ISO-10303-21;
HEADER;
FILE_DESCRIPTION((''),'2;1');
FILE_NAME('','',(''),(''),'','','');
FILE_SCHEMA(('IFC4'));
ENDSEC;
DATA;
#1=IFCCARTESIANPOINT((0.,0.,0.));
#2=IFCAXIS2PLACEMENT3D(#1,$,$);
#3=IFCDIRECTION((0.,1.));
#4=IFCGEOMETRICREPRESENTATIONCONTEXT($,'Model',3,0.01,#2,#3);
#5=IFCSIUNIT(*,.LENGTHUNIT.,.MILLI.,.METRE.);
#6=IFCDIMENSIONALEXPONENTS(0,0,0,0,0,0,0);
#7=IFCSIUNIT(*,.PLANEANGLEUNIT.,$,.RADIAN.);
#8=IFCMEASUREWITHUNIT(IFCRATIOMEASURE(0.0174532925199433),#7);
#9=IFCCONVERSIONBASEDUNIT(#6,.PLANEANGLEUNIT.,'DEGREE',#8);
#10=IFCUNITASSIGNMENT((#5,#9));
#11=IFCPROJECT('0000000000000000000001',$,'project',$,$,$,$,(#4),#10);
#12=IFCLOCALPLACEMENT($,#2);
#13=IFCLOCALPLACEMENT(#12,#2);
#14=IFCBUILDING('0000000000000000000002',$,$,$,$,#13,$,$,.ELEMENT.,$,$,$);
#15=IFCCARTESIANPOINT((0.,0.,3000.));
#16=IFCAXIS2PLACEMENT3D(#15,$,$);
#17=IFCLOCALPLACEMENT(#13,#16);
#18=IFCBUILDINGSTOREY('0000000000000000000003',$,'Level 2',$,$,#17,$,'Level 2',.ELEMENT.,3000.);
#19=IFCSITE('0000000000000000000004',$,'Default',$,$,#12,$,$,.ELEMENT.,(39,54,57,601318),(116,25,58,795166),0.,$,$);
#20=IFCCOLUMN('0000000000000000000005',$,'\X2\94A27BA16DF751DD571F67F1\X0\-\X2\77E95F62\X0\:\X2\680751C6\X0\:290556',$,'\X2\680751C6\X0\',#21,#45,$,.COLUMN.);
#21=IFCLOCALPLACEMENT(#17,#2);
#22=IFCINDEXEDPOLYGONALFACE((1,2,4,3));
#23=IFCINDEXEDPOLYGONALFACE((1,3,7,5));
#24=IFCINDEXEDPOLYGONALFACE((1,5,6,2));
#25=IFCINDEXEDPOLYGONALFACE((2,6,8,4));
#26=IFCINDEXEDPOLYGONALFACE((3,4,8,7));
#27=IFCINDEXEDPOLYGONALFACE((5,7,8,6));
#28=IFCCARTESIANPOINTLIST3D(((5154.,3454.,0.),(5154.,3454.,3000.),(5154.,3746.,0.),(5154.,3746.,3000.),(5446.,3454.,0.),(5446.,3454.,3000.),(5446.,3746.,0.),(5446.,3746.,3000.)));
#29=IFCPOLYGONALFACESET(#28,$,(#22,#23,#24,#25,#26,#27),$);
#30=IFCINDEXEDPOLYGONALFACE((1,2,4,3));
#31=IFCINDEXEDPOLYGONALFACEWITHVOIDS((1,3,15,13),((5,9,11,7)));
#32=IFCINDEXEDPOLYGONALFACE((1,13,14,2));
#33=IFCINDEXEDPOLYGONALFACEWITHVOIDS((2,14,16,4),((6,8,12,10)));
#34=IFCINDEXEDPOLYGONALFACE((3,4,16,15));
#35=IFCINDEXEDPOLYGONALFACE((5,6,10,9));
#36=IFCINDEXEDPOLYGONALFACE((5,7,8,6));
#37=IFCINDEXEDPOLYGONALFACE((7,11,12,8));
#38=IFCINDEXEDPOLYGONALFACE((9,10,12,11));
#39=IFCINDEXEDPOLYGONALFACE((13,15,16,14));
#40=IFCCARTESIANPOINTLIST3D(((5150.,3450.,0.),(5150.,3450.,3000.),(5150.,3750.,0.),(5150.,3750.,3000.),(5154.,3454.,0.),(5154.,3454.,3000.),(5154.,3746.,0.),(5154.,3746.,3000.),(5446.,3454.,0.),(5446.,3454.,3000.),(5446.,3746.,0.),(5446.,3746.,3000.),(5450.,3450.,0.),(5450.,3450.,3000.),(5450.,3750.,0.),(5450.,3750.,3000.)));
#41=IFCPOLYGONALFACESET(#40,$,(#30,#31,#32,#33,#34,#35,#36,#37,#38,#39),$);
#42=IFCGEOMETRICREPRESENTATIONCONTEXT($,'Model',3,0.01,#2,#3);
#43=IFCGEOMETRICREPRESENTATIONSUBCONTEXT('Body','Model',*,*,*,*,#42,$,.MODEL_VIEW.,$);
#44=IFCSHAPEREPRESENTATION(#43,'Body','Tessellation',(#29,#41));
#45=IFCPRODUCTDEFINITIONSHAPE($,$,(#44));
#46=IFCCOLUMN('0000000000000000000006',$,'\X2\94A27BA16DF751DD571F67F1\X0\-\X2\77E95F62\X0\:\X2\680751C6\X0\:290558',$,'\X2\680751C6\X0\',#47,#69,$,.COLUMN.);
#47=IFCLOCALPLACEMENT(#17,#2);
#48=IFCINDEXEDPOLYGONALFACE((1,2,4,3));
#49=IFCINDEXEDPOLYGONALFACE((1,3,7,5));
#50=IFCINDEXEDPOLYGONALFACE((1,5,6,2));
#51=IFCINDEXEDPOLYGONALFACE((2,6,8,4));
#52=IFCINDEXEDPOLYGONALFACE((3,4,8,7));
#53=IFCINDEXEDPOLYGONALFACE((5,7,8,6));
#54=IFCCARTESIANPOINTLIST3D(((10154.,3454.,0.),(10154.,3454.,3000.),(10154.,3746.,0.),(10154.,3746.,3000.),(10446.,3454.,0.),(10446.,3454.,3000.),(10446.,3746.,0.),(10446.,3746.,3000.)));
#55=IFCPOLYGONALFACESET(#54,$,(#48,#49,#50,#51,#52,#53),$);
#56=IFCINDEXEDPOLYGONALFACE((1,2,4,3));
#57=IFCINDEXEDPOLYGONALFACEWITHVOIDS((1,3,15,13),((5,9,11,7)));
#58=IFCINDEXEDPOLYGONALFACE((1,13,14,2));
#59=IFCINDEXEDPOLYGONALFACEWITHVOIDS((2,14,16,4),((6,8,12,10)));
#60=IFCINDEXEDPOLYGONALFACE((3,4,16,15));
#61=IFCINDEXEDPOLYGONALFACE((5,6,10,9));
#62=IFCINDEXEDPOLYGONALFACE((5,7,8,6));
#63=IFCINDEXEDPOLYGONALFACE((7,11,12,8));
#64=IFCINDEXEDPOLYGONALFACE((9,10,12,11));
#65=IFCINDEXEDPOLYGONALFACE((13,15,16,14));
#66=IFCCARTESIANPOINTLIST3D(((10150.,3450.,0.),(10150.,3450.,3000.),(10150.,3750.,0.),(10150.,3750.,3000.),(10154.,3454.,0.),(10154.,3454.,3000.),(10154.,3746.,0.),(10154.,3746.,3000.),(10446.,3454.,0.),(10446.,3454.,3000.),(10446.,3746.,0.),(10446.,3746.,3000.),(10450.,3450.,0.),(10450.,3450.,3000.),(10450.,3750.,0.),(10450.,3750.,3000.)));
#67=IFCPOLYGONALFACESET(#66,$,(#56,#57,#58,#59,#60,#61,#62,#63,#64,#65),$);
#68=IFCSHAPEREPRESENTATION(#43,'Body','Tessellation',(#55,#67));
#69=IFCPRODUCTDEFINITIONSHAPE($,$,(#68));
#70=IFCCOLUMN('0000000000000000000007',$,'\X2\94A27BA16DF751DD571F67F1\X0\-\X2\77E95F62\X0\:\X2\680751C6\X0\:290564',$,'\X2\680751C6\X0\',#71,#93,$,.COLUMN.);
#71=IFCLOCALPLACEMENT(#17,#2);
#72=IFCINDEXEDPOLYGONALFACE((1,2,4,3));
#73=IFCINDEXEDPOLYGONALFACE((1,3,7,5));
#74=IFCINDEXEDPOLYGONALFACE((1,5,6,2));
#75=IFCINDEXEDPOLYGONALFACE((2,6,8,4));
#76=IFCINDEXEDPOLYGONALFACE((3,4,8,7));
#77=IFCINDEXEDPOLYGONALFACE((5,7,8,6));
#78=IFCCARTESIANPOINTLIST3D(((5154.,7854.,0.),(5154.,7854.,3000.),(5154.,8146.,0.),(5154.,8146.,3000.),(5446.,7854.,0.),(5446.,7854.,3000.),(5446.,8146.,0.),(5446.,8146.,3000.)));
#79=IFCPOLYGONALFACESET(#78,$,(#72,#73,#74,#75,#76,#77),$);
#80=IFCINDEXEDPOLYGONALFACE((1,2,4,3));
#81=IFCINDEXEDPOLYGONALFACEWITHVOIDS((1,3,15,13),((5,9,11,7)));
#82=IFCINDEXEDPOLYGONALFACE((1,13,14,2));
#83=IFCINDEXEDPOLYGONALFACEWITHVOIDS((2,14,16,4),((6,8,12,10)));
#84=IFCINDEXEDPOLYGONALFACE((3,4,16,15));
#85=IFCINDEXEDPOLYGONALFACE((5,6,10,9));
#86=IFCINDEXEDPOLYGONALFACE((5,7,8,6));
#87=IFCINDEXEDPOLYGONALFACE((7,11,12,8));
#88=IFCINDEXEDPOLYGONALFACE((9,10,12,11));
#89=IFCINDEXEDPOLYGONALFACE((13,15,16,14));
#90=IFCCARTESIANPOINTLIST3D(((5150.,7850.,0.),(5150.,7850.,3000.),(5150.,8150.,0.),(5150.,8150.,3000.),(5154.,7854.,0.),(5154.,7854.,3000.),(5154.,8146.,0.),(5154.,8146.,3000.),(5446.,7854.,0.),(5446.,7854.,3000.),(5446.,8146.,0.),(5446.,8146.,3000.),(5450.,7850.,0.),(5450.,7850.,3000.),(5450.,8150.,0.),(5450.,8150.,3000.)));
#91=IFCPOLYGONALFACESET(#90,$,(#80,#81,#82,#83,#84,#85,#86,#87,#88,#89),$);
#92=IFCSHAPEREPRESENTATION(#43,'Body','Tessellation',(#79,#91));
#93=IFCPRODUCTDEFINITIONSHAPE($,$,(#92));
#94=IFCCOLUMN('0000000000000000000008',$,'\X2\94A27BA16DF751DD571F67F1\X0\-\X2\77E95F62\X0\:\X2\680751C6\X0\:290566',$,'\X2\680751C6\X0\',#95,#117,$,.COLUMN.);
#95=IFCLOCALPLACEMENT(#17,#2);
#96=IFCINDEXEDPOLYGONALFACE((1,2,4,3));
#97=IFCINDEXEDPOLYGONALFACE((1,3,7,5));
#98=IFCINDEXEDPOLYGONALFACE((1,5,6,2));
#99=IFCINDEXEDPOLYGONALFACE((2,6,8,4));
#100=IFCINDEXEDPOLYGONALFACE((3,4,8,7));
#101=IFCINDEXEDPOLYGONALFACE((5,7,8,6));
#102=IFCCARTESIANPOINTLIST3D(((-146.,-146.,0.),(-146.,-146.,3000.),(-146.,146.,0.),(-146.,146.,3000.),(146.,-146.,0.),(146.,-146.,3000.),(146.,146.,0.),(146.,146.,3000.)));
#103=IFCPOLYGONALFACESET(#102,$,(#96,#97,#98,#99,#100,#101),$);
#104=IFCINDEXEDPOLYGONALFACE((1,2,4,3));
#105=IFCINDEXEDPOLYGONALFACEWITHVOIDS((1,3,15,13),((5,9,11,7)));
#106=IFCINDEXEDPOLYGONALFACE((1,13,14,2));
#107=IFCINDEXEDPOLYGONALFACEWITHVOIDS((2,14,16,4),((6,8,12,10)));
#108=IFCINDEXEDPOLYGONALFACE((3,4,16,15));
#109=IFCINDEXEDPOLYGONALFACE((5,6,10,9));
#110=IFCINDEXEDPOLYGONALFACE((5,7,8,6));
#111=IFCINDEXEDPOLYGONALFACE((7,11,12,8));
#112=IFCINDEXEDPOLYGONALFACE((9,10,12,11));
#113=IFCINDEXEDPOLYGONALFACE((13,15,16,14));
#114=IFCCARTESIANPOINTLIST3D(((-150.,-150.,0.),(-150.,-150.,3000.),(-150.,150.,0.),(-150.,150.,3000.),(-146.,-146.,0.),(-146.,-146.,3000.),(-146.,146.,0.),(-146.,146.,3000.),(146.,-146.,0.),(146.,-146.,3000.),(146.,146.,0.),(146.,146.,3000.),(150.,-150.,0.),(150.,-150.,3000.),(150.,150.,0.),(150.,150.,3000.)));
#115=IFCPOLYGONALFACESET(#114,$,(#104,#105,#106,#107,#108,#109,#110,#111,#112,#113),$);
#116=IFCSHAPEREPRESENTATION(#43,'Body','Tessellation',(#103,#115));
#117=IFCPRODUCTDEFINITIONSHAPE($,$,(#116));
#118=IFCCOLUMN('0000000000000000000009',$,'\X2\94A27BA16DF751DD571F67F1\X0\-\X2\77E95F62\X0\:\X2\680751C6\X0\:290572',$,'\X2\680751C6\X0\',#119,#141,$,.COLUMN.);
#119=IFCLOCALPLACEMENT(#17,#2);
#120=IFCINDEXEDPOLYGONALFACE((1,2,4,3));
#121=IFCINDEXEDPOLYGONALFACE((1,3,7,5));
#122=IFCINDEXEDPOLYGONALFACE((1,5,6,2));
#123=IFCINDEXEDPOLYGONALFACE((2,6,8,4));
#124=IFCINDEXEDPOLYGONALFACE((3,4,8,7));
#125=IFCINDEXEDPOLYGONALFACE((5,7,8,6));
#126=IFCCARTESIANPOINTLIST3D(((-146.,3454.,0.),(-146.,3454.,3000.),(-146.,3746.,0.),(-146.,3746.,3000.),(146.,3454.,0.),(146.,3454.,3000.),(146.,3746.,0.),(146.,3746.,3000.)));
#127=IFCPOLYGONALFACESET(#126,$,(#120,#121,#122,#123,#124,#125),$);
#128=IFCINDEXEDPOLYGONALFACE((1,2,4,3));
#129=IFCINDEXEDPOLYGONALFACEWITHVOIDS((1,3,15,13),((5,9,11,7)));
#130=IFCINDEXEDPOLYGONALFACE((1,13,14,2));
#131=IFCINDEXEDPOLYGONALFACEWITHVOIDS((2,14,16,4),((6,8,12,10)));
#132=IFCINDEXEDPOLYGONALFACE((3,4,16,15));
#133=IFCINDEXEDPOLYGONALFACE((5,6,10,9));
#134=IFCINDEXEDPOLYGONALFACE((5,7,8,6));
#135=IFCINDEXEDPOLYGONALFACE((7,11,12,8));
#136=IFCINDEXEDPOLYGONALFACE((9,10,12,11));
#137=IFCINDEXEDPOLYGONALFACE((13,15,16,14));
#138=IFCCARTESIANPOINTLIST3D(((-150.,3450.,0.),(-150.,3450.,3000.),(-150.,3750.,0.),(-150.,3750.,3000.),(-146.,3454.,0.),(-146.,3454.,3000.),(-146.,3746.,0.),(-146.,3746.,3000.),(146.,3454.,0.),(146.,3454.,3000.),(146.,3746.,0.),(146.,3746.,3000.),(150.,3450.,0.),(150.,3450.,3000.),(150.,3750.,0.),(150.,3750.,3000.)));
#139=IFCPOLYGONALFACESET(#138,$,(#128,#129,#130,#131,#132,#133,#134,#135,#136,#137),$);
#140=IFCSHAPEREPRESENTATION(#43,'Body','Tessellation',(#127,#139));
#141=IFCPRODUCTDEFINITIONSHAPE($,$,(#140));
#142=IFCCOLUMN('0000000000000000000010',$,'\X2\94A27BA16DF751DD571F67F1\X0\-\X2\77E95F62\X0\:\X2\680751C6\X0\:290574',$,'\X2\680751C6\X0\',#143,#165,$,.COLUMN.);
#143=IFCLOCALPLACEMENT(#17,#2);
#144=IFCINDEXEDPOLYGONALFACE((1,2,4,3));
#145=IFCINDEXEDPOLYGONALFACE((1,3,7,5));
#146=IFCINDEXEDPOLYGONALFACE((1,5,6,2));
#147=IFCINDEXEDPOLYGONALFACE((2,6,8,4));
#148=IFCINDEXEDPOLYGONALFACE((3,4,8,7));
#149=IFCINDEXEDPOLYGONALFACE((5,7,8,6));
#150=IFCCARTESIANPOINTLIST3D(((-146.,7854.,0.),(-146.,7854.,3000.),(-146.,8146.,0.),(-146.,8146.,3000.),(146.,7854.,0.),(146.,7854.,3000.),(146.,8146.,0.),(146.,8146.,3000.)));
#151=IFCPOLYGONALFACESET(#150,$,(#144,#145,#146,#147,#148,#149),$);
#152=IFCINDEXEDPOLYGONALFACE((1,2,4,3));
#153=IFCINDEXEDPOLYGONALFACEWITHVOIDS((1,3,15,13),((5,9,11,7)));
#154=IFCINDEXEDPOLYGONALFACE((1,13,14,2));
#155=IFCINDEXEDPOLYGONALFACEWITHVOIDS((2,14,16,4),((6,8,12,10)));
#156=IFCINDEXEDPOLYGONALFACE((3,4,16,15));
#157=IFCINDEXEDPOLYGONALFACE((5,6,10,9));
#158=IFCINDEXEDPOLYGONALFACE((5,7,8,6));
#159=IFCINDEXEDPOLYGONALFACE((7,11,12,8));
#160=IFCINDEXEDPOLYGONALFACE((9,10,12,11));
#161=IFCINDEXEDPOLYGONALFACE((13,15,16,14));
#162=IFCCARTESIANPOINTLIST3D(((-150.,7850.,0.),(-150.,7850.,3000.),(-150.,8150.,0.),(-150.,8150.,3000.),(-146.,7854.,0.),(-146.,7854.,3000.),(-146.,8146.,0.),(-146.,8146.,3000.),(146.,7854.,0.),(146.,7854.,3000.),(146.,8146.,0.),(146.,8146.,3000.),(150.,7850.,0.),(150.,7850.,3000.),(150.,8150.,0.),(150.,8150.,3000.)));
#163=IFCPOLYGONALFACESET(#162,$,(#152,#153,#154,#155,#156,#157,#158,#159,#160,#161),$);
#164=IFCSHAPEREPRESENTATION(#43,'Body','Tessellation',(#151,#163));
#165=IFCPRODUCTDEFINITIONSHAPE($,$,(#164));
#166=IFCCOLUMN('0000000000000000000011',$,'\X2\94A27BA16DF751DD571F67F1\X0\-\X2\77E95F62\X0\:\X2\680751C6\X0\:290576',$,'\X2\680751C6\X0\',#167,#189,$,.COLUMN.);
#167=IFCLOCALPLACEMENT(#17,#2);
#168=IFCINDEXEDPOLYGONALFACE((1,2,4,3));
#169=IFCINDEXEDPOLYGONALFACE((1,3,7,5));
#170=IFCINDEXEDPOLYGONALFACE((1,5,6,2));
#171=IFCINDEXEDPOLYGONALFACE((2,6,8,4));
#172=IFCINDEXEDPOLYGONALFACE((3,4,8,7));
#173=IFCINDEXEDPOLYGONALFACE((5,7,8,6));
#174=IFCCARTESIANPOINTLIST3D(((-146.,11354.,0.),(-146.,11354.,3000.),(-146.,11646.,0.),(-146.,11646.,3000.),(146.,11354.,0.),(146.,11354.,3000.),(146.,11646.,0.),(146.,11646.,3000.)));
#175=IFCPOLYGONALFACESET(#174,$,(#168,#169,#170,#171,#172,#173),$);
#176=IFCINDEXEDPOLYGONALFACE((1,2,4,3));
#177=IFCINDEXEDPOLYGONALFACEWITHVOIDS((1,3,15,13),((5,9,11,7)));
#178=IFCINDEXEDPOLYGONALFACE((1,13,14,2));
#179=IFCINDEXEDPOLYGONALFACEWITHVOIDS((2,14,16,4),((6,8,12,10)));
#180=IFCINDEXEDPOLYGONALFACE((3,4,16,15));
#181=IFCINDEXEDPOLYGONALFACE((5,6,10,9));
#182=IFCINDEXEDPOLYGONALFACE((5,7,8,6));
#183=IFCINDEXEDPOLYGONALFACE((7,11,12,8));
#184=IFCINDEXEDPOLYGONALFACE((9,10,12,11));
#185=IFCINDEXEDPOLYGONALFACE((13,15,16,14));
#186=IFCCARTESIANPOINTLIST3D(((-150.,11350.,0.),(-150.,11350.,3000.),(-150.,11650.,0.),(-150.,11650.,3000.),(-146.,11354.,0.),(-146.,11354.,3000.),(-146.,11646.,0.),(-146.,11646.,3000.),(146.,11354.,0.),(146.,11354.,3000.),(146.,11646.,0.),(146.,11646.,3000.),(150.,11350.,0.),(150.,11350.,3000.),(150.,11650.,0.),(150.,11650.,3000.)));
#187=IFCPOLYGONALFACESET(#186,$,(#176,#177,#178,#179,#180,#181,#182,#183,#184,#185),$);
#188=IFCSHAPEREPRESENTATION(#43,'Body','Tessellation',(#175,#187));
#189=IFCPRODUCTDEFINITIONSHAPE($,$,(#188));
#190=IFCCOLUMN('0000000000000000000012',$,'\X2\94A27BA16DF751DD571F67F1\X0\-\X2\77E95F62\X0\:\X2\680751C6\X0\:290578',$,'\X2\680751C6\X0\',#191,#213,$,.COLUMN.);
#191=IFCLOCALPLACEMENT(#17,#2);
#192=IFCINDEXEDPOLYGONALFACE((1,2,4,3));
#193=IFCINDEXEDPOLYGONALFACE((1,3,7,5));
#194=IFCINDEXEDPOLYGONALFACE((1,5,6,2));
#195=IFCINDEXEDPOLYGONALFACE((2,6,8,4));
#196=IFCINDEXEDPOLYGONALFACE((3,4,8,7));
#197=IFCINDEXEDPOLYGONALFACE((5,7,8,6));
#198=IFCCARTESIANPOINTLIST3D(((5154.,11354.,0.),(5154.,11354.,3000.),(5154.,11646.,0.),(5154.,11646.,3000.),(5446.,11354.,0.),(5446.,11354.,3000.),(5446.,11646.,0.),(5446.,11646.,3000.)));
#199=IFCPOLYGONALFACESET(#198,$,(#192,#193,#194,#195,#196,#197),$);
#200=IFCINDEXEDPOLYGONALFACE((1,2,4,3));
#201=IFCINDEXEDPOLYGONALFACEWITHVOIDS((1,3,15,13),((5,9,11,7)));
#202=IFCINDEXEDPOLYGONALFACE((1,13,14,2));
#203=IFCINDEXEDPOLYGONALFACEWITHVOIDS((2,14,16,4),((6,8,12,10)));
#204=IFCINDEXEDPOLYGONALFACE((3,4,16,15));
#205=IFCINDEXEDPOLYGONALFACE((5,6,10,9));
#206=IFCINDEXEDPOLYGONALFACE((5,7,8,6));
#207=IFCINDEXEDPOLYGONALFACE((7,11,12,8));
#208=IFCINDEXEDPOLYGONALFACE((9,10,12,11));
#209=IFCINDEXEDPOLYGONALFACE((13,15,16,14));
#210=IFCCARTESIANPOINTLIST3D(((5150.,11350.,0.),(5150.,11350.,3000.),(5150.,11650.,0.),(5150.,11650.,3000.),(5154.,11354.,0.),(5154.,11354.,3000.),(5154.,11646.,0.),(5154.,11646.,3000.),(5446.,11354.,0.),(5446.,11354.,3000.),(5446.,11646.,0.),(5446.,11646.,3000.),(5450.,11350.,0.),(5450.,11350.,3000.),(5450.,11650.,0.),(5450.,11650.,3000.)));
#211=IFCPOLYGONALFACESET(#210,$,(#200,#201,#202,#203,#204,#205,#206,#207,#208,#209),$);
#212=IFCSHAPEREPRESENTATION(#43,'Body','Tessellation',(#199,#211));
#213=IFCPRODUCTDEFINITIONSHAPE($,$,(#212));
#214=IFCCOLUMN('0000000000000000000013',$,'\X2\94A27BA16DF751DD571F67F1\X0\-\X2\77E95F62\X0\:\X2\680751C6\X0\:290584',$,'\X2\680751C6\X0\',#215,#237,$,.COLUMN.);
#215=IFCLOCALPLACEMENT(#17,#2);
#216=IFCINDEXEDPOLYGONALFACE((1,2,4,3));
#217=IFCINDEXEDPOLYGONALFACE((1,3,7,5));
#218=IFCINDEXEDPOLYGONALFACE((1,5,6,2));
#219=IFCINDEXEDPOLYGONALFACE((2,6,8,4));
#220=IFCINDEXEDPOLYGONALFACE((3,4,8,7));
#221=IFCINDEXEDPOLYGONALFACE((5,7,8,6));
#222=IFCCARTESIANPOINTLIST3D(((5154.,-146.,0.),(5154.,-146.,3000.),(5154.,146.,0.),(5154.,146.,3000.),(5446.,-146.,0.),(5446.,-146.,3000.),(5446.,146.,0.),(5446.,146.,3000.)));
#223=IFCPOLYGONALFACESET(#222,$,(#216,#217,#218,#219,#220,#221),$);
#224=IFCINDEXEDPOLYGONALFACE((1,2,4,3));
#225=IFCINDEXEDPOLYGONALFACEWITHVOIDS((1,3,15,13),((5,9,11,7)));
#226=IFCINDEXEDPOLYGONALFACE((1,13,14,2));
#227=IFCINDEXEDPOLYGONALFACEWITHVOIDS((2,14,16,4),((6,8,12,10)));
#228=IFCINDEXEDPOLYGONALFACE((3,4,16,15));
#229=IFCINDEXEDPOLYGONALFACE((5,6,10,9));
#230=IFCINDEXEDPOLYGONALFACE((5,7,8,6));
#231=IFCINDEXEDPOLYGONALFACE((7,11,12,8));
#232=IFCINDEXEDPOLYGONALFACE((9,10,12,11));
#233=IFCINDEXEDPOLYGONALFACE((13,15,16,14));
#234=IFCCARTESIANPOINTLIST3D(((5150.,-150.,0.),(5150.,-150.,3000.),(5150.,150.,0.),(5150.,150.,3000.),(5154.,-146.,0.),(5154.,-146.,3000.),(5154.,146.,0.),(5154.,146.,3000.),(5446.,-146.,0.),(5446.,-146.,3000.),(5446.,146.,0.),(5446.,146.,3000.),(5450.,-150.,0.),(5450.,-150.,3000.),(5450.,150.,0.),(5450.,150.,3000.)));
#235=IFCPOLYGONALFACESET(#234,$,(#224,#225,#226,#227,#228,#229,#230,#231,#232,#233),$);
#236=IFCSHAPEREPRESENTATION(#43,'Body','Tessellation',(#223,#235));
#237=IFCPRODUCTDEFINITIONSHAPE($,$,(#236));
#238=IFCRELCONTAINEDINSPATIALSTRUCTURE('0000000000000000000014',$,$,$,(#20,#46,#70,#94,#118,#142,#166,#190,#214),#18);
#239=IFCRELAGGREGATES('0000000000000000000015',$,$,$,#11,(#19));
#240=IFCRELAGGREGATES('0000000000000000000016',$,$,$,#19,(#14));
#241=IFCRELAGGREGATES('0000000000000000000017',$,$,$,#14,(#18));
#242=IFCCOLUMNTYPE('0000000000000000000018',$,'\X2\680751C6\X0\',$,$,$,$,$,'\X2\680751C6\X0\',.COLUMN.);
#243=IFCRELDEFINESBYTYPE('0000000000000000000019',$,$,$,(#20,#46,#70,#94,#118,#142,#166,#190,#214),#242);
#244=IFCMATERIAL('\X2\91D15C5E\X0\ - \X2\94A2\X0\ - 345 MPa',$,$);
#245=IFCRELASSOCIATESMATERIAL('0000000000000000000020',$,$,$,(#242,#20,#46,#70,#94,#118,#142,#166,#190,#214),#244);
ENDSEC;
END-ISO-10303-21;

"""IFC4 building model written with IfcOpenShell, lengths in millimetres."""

from ifc_helpers import new_model, entity, si_unit, converted_unit, direction, frame, origin, origin_2d_with_axis, place, context, subcontext, project, spatial, polyline, rectangle, outline, extrude, source, transform, mapped, material, type_object, type_shapes, element, save


model = new_model("IFC4")

# Units and contexts
model_context_1 = context("Model", 3, precision=0.01, world=origin(), true_north=direction((0.0, 1.0)))
model_context_2 = context("Model", 3, precision=0.01, world=origin(), true_north=direction((0.0, 1.0)))
body_context = subcontext(model_context_2, "Body", "Model", "MODEL_VIEW")
ifc_project = project(units=[si_unit("LENGTHUNIT", "METRE", prefix="MILLI"), converted_unit("PLANEANGLEUNIT", "DEGREE", entity("IfcRatioMeasure", 0.0174532925199433), si_unit("PLANEANGLEUNIT", "RADIAN"), dimensions=[0, 0, 0, 0, 0, 0, 0])], contexts=[model_context_1])

# Site, building, storey
site_placement = place(None, origin())
site = spatial("IfcSite", under=ifc_project, at=site_placement, Name="Default", CompositionType="ELEMENT", RefLatitude=(39, 54, 57, 601318), RefLongitude=(116, 25, 58, 795166), RefElevation=0.0)
building_placement = place(site_placement, origin())
building = spatial("IfcBuilding", under=site, at=building_placement, CompositionType="ELEMENT")
storey_placement = place(building_placement, frame((0.0, 0.0, 3000.0)))
storey = spatial("IfcBuildingStorey", under=building, at=storey_placement, Name="Level 2", LongName="Level 2", CompositionType="ELEMENT", Elevation=3000.0)

# Columns
ifc_material_1 = material(Name="金属 - 钢 - 345 MPa")
column_type = type_object("IfcColumnType", Name="标准", ElementType="标准", PredefinedType="COLUMN", material=ifc_material_1)
shared_shape_1 = source(origin(), body_context, "Body", "SweptSolid", [
    extrude(rectangle(XDim=292.0, YDim=292.0, at=origin_2d_with_axis()), frame((150.0, 150.0, 0.0), z_axis=(0.0, 0.0, 1.0), x_axis=(-1.0, 0.0, 0.0)), (0.0, 0.0, 1.0), 3000.0),
    extrude(outline(polyline([(-150.0, -150.0), (150.0, -150.0), (150.0, 150.0), (-150.0, 150.0), (-150.0, -150.0)]), holes=[polyline([(-146.0, -146.0), (-146.0, 146.0), (146.0, 146.0), (146.0, -146.0), (-146.0, -146.0)])]), frame((150.0, 150.0, 0.0), z_axis=(0.0, 0.0, 1.0), x_axis=(-1.0, 0.0, 0.0)), (0.0, 0.0, 1.0), 3000.0),
])
type_shapes(column_type, [shared_shape_1])
for number, where, name in (
    (1, (5150.0, 3450.0, 0.0), "钢管混凝土柱-矩形:标准:290556"),
    (2, (10150.0, 3450.0, 0.0), "钢管混凝土柱-矩形:标准:290558"),
    (3, (5150.0, 7850.0, 0.0), "钢管混凝土柱-矩形:标准:290564"),
    (4, (-150.0, -150.0, 0.0), "钢管混凝土柱-矩形:标准:290566"),
    (5, (-150.0, 3450.0, 0.0), "钢管混凝土柱-矩形:标准:290572"),
    (6, (-150.0, 7850.0, 0.0), "钢管混凝土柱-矩形:标准:290574"),
    (7, (-150.0, 11350.0, 0.0), "钢管混凝土柱-矩形:标准:290576"),
    (8, (5150.0, 11350.0, 0.0), "钢管混凝土柱-矩形:标准:290578"),
    (9, (5150.0, -150.0, 0.0), "钢管混凝土柱-矩形:标准:290584"),
):
    element("IfcColumn", number, at=place(storey_placement, frame(where)), inside=storey, type_object=column_type, material=ifc_material_1, Name=name, ObjectType="标准", PredefinedType="COLUMN", context=body_context, shape_type="MappedRepresentation", body=[
        mapped(shared_shape_1, transform((0.0, 0.0, 0.0), scale=1.0)),
    ])

save(model, "model.ifc")
